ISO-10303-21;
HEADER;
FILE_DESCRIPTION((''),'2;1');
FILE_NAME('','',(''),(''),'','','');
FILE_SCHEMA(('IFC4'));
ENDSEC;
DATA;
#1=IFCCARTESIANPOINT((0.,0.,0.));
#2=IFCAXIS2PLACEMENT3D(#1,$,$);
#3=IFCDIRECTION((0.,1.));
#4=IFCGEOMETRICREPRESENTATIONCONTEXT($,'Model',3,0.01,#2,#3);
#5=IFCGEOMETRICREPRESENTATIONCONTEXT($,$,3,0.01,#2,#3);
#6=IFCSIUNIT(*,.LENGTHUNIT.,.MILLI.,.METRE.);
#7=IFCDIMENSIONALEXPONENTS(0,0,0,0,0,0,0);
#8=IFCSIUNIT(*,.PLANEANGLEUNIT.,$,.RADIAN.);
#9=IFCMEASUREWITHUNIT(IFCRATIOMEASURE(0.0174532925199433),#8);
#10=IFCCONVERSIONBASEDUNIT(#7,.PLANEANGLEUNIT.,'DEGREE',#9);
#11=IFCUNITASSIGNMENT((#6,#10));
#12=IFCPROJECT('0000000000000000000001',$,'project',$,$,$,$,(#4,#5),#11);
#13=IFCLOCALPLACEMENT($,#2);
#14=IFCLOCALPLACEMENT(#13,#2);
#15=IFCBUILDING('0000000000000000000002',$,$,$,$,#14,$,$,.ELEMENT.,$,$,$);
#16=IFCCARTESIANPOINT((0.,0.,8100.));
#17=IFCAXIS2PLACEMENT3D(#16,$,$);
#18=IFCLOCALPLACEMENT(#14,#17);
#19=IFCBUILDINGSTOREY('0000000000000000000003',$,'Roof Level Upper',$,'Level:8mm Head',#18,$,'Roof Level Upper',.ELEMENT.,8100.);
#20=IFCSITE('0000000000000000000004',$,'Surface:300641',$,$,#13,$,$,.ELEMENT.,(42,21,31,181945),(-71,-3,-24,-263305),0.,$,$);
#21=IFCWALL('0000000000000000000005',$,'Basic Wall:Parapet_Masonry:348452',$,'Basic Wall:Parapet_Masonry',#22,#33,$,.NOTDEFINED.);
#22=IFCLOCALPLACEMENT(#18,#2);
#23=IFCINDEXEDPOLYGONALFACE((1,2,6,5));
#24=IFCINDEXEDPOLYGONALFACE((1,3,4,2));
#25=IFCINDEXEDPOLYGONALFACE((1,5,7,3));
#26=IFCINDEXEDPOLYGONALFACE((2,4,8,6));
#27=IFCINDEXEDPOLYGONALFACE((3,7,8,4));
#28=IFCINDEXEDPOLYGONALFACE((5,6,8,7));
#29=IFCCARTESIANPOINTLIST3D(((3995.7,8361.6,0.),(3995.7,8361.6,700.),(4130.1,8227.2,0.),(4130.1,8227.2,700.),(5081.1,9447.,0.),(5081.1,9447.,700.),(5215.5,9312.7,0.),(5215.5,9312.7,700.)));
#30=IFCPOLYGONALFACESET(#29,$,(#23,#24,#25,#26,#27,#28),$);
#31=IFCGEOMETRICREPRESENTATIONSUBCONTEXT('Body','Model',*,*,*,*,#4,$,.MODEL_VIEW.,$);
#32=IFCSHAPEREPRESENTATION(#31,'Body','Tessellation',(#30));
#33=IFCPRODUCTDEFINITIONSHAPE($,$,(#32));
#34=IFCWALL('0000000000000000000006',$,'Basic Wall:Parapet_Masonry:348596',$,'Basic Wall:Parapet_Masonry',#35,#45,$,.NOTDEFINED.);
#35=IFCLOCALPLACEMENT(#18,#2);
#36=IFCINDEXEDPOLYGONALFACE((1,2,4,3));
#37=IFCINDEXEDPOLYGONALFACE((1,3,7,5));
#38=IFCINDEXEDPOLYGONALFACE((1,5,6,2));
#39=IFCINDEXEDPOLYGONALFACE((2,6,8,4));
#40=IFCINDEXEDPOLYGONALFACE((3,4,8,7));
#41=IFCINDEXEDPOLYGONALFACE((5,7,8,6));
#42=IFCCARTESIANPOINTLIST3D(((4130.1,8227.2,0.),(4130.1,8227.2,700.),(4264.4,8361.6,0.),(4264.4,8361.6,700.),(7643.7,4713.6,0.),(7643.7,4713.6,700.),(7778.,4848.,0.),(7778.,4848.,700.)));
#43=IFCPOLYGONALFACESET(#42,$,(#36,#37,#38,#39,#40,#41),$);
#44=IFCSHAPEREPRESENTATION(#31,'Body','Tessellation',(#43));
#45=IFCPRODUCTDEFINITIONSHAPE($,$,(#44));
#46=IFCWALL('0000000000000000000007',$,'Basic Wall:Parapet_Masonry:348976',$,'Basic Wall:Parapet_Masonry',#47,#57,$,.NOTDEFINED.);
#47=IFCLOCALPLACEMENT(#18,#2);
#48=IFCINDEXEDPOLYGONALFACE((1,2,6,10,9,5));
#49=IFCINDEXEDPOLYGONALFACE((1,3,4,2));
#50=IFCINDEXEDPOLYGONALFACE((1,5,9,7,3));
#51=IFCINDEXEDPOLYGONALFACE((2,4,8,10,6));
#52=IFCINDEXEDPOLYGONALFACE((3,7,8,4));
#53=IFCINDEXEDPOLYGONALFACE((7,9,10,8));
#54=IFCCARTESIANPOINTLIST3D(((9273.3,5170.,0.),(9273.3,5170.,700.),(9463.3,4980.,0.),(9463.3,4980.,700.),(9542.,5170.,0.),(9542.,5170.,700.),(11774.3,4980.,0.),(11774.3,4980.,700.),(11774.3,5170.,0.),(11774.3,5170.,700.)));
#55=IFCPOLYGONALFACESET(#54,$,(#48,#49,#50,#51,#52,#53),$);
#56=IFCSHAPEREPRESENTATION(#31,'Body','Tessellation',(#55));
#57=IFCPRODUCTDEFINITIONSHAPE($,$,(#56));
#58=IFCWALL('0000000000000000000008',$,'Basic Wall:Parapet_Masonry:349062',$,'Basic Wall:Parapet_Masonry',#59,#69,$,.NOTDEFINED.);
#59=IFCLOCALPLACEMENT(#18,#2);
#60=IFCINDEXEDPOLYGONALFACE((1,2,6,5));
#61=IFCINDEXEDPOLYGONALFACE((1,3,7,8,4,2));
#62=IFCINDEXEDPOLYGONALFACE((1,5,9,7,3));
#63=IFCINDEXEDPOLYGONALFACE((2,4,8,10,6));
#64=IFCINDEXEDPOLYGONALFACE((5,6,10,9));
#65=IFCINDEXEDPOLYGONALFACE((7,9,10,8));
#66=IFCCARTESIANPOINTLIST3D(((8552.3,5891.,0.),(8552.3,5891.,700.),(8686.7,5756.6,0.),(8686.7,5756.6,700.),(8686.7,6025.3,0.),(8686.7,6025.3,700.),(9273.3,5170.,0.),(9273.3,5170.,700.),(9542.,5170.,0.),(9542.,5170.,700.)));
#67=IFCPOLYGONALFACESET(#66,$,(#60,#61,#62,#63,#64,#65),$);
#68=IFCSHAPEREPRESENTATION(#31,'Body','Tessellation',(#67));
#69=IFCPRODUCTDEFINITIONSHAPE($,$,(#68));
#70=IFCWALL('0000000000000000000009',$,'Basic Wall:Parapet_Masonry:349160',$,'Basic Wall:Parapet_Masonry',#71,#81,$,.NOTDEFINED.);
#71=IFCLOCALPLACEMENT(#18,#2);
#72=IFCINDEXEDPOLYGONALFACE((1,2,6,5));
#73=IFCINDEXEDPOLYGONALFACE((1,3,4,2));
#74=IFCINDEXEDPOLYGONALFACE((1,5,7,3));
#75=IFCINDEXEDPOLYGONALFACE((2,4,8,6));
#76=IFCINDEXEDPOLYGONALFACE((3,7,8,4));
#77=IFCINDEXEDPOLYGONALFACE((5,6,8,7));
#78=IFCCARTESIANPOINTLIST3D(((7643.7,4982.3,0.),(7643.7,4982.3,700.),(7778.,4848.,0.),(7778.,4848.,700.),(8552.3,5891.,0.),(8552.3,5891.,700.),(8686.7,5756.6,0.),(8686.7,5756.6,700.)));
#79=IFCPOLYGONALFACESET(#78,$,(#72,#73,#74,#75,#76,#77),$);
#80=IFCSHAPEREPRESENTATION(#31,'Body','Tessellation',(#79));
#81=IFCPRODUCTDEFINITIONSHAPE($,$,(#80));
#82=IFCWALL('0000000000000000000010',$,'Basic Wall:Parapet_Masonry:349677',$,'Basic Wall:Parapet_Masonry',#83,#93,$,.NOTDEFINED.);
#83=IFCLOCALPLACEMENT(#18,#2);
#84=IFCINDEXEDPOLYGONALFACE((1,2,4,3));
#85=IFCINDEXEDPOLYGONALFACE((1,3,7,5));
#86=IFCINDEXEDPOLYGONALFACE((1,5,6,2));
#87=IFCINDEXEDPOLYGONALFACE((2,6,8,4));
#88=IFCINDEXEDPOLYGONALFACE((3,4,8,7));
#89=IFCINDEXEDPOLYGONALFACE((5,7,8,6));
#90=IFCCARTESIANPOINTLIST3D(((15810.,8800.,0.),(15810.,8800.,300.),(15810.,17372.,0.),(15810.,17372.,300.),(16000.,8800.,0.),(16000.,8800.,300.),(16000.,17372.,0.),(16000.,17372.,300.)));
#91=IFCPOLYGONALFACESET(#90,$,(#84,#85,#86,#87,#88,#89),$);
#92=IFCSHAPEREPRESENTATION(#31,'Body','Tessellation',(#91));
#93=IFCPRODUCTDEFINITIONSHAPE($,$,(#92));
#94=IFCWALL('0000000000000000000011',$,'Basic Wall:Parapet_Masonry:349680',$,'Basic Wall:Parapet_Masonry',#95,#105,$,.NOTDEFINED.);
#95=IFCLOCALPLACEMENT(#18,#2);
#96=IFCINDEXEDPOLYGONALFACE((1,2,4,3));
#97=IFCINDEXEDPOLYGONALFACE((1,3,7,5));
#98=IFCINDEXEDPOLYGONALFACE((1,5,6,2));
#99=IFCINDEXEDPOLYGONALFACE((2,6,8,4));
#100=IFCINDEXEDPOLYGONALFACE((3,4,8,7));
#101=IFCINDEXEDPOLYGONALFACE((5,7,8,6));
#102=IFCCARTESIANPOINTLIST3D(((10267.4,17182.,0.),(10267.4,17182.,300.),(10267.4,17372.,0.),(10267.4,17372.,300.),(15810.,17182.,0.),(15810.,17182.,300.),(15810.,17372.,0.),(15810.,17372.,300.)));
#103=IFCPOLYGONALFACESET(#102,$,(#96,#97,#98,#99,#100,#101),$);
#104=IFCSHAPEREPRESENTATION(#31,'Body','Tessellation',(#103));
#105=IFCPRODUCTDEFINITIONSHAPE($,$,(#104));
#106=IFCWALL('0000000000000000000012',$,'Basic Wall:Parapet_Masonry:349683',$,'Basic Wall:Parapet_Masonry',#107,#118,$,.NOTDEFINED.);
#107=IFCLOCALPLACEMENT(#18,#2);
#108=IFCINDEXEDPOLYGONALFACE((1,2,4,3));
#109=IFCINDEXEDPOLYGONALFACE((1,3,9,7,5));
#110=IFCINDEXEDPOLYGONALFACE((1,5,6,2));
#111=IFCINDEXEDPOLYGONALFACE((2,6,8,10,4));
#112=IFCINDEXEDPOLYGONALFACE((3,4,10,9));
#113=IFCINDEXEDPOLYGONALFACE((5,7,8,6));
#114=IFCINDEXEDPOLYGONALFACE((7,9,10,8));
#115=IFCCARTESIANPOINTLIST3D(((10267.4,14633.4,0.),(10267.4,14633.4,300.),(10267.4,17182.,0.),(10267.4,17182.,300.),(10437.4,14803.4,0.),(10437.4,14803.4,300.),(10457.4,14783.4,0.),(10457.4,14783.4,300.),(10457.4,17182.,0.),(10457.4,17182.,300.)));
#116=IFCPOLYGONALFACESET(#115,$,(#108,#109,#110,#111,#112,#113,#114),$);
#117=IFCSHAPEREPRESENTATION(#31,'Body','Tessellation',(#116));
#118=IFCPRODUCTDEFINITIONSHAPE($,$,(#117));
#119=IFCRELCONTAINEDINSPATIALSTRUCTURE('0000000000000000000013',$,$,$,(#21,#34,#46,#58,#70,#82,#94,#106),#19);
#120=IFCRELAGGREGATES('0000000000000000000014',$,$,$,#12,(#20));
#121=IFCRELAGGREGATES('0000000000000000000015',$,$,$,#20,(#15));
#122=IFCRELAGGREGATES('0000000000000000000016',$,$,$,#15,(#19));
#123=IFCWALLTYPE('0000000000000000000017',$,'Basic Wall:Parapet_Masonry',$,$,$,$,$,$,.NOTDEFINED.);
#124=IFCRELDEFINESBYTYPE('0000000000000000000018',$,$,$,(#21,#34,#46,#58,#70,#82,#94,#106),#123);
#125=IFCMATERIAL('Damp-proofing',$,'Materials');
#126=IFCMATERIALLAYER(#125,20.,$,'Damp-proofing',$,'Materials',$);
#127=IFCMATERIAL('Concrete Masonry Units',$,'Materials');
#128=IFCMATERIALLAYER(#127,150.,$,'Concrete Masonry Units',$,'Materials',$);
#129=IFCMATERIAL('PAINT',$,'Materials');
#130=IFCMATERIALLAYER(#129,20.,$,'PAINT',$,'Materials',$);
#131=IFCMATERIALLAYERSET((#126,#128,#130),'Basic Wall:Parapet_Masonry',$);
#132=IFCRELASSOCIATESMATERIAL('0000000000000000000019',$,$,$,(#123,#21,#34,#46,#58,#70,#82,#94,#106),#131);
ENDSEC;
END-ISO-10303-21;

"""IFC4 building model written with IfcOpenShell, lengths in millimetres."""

from ifc_helpers import new_model, entity, si_unit, converted_unit, direction, frame, frame_2d, origin, place, context, subcontext, project, spatial, polyline, rectangle, outline, extrude, clip, halfspace, material, layer, layer_set, layer_usage, type_object, element, save


model = new_model("IFC4")

# Units and contexts
model_context = context("Model", 3, precision=0.01, world=origin(), true_north=direction((0.0, 1.0)))
context_of_model = context(None, 3, precision=0.01, world=origin(), true_north=direction((0.0, 1.0)))
body_context = subcontext(model_context, "Body", "Model", "MODEL_VIEW")
ifc_project = project(units=[si_unit("LENGTHUNIT", "METRE", prefix="MILLI"), converted_unit("PLANEANGLEUNIT", "DEGREE", entity("IfcRatioMeasure", 0.0174532925199433), si_unit("PLANEANGLEUNIT", "RADIAN"), dimensions=[0, 0, 0, 0, 0, 0, 0])], contexts=[model_context, context_of_model])

# Site, building, storey
site_placement = place(None, origin())
site = spatial("IfcSite", under=ifc_project, at=site_placement, Name="Surface:300641", CompositionType="ELEMENT", RefLatitude=(42, 21, 31, 181945), RefLongitude=(-71, -3, -24, -263305), RefElevation=0.0)
building_placement = place(site_placement, origin())
building = spatial("IfcBuilding", under=site, at=building_placement, CompositionType="ELEMENT")
storey_placement = place(building_placement, frame((0.0, 0.0, 8100.0)))
storey = spatial("IfcBuildingStorey", under=building, at=storey_placement, Name="Roof Level Upper", ObjectType="Level:8mm Head", LongName="Roof Level Upper", CompositionType="ELEMENT", Elevation=8100.0)

# Shared definitions
ifc_material_1 = material(Name="Damp-proofing", Category="Materials")

# Walls
ifc_layer_1 = layer(ifc_material_1, 20.0, Name="Damp-proofing", Category="Materials")
ifc_material_2 = material(Name="Concrete Masonry Units", Category="Materials")
ifc_layer_2 = layer(ifc_material_2, 150.0, Name="Concrete Masonry Units", Category="Materials")
ifc_material_3 = material(Name="PAINT", Category="Materials")
ifc_layer_3 = layer(ifc_material_3, 20.0, Name="PAINT", Category="Materials")
ifc_layer_set_1 = layer_set([ifc_layer_1, ifc_layer_2, ifc_layer_3], Name="Basic Wall:Parapet_Masonry")
wall_type = type_object("IfcWallType", Name="Basic Wall:Parapet_Masonry", PredefinedType="NOTDEFINED", material=ifc_layer_set_1)
ifc_layer_usage_1 = layer_usage(ifc_layer_set_1, "AXIS2", "NEGATIVE", 95.0)
wall_1_placement = place(storey_placement, frame((5148.3, 9379.8, 0.0), z_axis=(0.0, 0.0, 1.0), x_axis=(-0.707107, -0.707107, 0.0)))
element("IfcWall", 1, at=wall_1_placement, inside=storey, type_object=wall_type, material=ifc_layer_usage_1, Name="Basic Wall:Parapet_Masonry:348452", ObjectType="Basic Wall:Parapet_Masonry", PredefinedType="NOTDEFINED", context=body_context, shape_type="SweptSolid", body=[
    extrude(rectangle(XDim=1535.0, YDim=190.0, at=frame_2d((767.5, 0.0), x_axis=(-1.0, 0.0))), origin(), (0.0, 0.0, 1.0), 700.0),
])
ifc_layer_usage_2 = layer_usage(ifc_layer_set_1, "AXIS2", "NEGATIVE", 95.0)
wall_2_placement = place(storey_placement, frame((4197.2, 8294.4, 0.0), z_axis=(0.0, 0.0, 1.0), x_axis=(0.707107, -0.707107, 0.0)))
element("IfcWall", 2, at=wall_2_placement, inside=storey, type_object=wall_type, material=ifc_layer_usage_2, Name="Basic Wall:Parapet_Masonry:348596", ObjectType="Basic Wall:Parapet_Masonry", PredefinedType="NOTDEFINED", context=body_context, shape_type="SweptSolid", body=[
    extrude(rectangle(XDim=4969.0, YDim=190.0, at=frame_2d((2484.5, 0.0), x_axis=(-1.0, 0.0))), origin(), (0.0, 0.0, 1.0), 700.0),
])
ifc_layer_usage_3 = layer_usage(ifc_layer_set_1, "AXIS2", "POSITIVE", -95.0)
wall_3_placement = place(storey_placement, frame((11774.3, 5075.0, 0.0), z_axis=(0.0, 0.0, 1.0), x_axis=(-1.0, 0.0, 0.0)))
element("IfcWall", 3, at=wall_3_placement, inside=storey, type_object=wall_type, material=ifc_layer_usage_3, Name="Basic Wall:Parapet_Masonry:348976", ObjectType="Basic Wall:Parapet_Masonry", PredefinedType="NOTDEFINED", context=body_context, shape_type="SweptSolid", body=[
    extrude(outline(polyline([(2501.0, -95.0), (2311.0, 95.0), (0.0, 95.0), (0.0, -95.0), (2232.3, -95.0), (2501.0, -95.0)])), origin(), (0.0, 0.0, 1.0), 700.0),
])
ifc_layer_usage_4 = layer_usage(ifc_layer_set_1, "AXIS2", "POSITIVE", -95.0)
wall_4_placement = place(storey_placement, frame((9474.8, 5102.8, 0.0), z_axis=(0.0, 0.0, 1.0), x_axis=(-0.707107, 0.707107, 0.0)))
element("IfcWall", 4, at=wall_4_placement, inside=storey, type_object=wall_type, material=ifc_layer_usage_4, Name="Basic Wall:Parapet_Masonry:349062", ObjectType="Basic Wall:Parapet_Masonry", PredefinedType="NOTDEFINED", context=body_context, shape_type="SweptSolid", body=[
    extrude(outline(polyline([(1209.6, -95.0), (1209.6, 95.0), (1019.6, 95.0), (190.0, 95.0), (0.0, -95.0), (1209.6, -95.0)])), origin(), (0.0, 0.0, 1.0), 700.0),
])
ifc_layer_usage_5 = layer_usage(ifc_layer_set_1, "AXIS2", "POSITIVE", -95.0)
wall_5_placement = place(storey_placement, frame((8619.5, 5823.8, 0.0), z_axis=(0.0, 0.0, 1.0), x_axis=(-0.707107, -0.707107, 0.0)))
element("IfcWall", 5, at=wall_5_placement, inside=storey, type_object=wall_type, material=ifc_layer_usage_5, Name="Basic Wall:Parapet_Masonry:349160", ObjectType="Basic Wall:Parapet_Masonry", PredefinedType="NOTDEFINED", context=body_context, shape_type="SweptSolid", body=[
    extrude(rectangle(XDim=1285.0, YDim=190.0, at=frame_2d((642.5, 0.0), x_axis=(-1.0, 0.0))), origin(), (0.0, 0.0, 1.0), 700.0),
])
ifc_layer_usage_6 = layer_usage(ifc_layer_set_1, "AXIS2", "NEGATIVE", 95.0)
wall_6_placement = place(storey_placement, frame((15905.0, 8800.0, 0.0), z_axis=(0.0, 0.0, 1.0), x_axis=(0.0, 1.0, 0.0)))
element("IfcWall", 6, at=wall_6_placement, inside=storey, type_object=wall_type, material=ifc_layer_usage_6, Name="Basic Wall:Parapet_Masonry:349677", ObjectType="Basic Wall:Parapet_Masonry", PredefinedType="NOTDEFINED", context=body_context, shape_type="Clipping", body=[
    clip(extrude(rectangle(XDim=8572.0, YDim=190.0, at=frame_2d((4286.0, 0.0), x_axis=(-1.0, 0.0))), origin(), (0.0, 0.0, 1.0), 300.0), halfspace(frame((0.0, 0.0, -400.0)), True)),
])
ifc_layer_usage_7 = layer_usage(ifc_layer_set_1, "AXIS2", "NEGATIVE", 95.0)
wall_7_placement = place(storey_placement, frame((15810.0, 17277.0, 0.0), z_axis=(0.0, 0.0, 1.0), x_axis=(-1.0, 0.0, 0.0)))
element("IfcWall", 7, at=wall_7_placement, inside=storey, type_object=wall_type, material=ifc_layer_usage_7, Name="Basic Wall:Parapet_Masonry:349680", ObjectType="Basic Wall:Parapet_Masonry", PredefinedType="NOTDEFINED", context=body_context, shape_type="Clipping", body=[
    clip(extrude(rectangle(XDim=5542.6, YDim=190.0, at=frame_2d((2771.3, 0.0), x_axis=(-1.0, 0.0))), origin(), (0.0, 0.0, 1.0), 300.0), halfspace(frame((0.0, 0.0, -400.0)), True)),
])
ifc_layer_usage_8 = layer_usage(ifc_layer_set_1, "AXIS2", "NEGATIVE", 95.0)
wall_8_placement = place(storey_placement, frame((10362.4, 17182.0, 0.0), z_axis=(0.0, 0.0, 1.0), x_axis=(0.0, -1.0, 0.0)))
element("IfcWall", 8, at=wall_8_placement, inside=storey, type_object=wall_type, material=ifc_layer_usage_8, Name="Basic Wall:Parapet_Masonry:349683", ObjectType="Basic Wall:Parapet_Masonry", PredefinedType="NOTDEFINED", context=body_context, shape_type="Clipping", body=[
    clip(extrude(outline(polyline([(2548.6, -95.0), (2378.6, 75.0), (2398.6, 95.0), (0.0, 95.0), (0.0, -95.0), (2548.6, -95.0)])), origin(), (0.0, 0.0, 1.0), 300.0), halfspace(frame((0.0, 0.0, -400.0)), True)),
])

save(model, "model.ifc")
